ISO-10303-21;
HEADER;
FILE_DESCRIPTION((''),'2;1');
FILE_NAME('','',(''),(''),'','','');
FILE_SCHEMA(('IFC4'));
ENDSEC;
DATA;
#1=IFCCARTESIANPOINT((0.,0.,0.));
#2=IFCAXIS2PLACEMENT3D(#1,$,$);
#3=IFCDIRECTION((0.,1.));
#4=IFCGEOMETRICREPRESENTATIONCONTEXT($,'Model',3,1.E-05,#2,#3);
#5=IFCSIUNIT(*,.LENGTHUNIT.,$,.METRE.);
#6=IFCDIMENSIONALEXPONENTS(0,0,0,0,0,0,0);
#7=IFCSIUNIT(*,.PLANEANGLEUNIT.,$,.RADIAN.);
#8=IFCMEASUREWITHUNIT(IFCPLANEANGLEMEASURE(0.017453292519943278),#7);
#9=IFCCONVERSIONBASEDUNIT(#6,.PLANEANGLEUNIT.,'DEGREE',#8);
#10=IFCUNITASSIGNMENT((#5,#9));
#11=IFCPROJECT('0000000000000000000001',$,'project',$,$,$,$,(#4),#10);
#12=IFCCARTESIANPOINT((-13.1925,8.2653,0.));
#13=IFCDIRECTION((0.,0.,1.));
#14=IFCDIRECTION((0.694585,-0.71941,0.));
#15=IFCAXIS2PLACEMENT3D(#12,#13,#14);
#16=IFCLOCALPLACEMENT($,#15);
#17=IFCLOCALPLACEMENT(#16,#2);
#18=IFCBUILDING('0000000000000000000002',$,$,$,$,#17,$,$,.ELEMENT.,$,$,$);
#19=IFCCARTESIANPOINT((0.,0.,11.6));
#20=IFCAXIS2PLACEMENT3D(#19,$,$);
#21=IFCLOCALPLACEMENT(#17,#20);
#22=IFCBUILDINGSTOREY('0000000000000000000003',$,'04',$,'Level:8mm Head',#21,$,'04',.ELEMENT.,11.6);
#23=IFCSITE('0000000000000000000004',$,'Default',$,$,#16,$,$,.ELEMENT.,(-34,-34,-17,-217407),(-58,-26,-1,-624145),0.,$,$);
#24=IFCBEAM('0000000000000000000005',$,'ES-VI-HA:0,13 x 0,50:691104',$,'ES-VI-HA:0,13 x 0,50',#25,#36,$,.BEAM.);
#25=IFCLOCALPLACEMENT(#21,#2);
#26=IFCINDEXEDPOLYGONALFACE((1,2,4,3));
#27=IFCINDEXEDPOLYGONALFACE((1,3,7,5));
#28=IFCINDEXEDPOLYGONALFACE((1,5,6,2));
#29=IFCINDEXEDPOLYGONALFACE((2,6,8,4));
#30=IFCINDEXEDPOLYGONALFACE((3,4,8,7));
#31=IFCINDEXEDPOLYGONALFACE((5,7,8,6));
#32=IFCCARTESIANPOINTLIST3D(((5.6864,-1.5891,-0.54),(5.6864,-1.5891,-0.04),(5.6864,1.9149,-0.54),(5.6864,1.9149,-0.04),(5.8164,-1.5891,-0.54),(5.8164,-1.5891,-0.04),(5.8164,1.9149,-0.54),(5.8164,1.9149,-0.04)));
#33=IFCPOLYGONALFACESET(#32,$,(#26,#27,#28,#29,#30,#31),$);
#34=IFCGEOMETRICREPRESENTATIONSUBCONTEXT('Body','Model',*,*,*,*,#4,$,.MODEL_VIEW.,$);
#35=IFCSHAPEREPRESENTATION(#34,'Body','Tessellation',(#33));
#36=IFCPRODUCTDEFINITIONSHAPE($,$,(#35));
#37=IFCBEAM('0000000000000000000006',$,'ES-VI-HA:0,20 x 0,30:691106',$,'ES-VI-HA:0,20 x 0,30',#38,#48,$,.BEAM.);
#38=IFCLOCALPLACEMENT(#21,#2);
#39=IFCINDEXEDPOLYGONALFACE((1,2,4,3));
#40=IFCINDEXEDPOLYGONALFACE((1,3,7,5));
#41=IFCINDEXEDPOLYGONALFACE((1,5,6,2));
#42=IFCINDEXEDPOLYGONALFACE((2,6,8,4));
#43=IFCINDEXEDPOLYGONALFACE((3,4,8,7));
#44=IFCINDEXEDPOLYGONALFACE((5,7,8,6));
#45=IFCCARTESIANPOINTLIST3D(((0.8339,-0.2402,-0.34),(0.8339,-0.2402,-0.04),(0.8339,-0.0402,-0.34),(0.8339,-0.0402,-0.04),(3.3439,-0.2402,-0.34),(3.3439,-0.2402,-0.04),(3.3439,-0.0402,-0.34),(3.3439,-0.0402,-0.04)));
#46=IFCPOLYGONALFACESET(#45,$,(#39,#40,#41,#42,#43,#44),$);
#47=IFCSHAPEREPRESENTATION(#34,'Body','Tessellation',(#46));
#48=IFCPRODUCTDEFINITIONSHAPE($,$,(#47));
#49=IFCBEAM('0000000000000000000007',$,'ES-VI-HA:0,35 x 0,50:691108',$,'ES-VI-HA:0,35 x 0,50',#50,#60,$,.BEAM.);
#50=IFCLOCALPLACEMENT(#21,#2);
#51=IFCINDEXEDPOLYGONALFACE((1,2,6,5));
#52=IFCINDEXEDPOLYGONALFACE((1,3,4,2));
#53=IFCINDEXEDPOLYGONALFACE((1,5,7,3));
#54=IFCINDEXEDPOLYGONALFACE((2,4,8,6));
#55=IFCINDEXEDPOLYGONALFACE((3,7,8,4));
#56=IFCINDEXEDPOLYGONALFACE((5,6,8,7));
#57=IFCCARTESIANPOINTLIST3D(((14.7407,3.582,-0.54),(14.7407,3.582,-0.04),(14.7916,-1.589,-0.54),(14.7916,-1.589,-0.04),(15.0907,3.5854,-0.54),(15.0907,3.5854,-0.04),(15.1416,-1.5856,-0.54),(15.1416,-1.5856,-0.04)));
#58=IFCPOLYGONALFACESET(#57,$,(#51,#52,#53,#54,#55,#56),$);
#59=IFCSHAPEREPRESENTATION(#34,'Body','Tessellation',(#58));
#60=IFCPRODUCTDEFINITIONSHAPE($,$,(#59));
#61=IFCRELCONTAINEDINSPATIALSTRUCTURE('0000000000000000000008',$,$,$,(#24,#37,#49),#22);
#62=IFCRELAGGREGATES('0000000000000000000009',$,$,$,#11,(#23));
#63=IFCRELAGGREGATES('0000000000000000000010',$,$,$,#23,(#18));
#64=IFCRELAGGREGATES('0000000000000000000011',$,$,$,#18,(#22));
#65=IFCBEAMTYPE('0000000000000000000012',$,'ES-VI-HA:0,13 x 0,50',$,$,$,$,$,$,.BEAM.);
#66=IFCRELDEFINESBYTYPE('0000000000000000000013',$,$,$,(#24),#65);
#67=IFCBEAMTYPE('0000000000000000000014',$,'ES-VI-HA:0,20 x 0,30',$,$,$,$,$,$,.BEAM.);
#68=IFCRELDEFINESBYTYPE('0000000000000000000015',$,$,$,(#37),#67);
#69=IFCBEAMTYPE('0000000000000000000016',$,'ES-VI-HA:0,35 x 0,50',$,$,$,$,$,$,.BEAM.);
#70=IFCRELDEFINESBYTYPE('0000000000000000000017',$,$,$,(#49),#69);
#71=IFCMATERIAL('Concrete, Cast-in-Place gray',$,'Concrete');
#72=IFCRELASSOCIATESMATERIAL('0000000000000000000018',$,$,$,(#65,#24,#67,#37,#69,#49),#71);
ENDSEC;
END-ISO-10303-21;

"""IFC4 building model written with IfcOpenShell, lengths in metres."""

from ifc_helpers import new_model, entity, si_unit, converted_unit, direction, frame, origin, place, context, subcontext, project, spatial, indexed_curve, outline, extrude, source, transform, mapped, material, type_object, type_shapes, element, save


model = new_model("IFC4")

# Units and contexts
model_context = context("Model", 3, precision=1e-05, world=origin(), true_north=direction((0.0, 1.0)))
body_context = subcontext(model_context, "Body", "Model", "MODEL_VIEW")
ifc_project = project(units=[si_unit("LENGTHUNIT", "METRE"), converted_unit("PLANEANGLEUNIT", "DEGREE", entity("IfcPlaneAngleMeasure", 0.017453292519943278), si_unit("PLANEANGLEUNIT", "RADIAN"), dimensions=[0, 0, 0, 0, 0, 0, 0])], contexts=[model_context])

# Site, building, storey
site_placement = place(None, frame((-13.1925, 8.2653, 0.0), z_axis=(0.0, 0.0, 1.0), x_axis=(0.694585, -0.71941, 0.0)))
site = spatial("IfcSite", under=ifc_project, at=site_placement, Name="Default", CompositionType="ELEMENT", RefLatitude=(-34, -34, -17, -217407), RefLongitude=(-58, -26, -1, -624145), RefElevation=0.0)
building_placement = place(site_placement, origin())
building = spatial("IfcBuilding", under=site, at=building_placement, CompositionType="ELEMENT")
storey_placement = place(building_placement, frame((0.0, 0.0, 11.6)))
storey = spatial("IfcBuildingStorey", under=building, at=storey_placement, Name="04", ObjectType="Level:8mm Head", LongName="04", CompositionType="ELEMENT", Elevation=11.6)

# Beams
ifc_material = material(Name="Concrete, Cast-in-Place gray", Category="Concrete")
beam_type_1 = type_object("IfcBeamType", Name="ES-VI-HA:0,13 x 0,50", PredefinedType="BEAM", material=ifc_material)
shared_shape_1 = source(origin(), body_context, "Body", "SweptSolid", [
    extrude(outline(indexed_curve([(-0.065, -0.25), (0.065, -0.25), (0.065, 0.25), (-0.065, 0.25), (-0.065, -0.25)], self_intersect=False)), frame((5.7514, -1.5891, 11.31), z_axis=(0.0, 1.0, 0.0), x_axis=(-1.0, 0.0, 0.0)), (0.0, 0.0, 1.0), 3.5039),
])
type_shapes(beam_type_1, [shared_shape_1])
beam_1_placement = place(storey_placement, frame((0.0, 0.0, -11.6)))
element("IfcBeam", 1, at=beam_1_placement, inside=storey, type_object=beam_type_1, material=ifc_material, Name="ES-VI-HA:0,13 x 0,50:691104", ObjectType="ES-VI-HA:0,13 x 0,50", PredefinedType="BEAM", context=body_context, shape_type="MappedRepresentation", body=[
    mapped(shared_shape_1, transform((0.0, 0.0, 0.0), scale=1.0)),
])
beam_type_2 = type_object("IfcBeamType", Name="ES-VI-HA:0,20 x 0,30", PredefinedType="BEAM", material=ifc_material)
shared_shape_2 = source(origin(), body_context, "Body", "SweptSolid", [
    extrude(outline(indexed_curve([(-0.15, -0.1), (0.15, -0.1), (0.15, 0.1), (-0.15, 0.1), (-0.15, -0.1)], self_intersect=False)), frame((0.8339, -0.1402, 11.41), z_axis=(1.0, 0.0, 0.0), x_axis=(0.0, 0.0, -1.0)), (0.0, 0.0, 1.0), 2.51),
])
type_shapes(beam_type_2, [shared_shape_2])
beam_2_placement = place(storey_placement, frame((0.0, 0.0, -11.6)))
element("IfcBeam", 2, at=beam_2_placement, inside=storey, type_object=beam_type_2, material=ifc_material, Name="ES-VI-HA:0,20 x 0,30:691106", ObjectType="ES-VI-HA:0,20 x 0,30", PredefinedType="BEAM", context=body_context, shape_type="MappedRepresentation", body=[
    mapped(shared_shape_2, transform((0.0, 0.0, 0.0), scale=1.0)),
])
beam_type_3 = type_object("IfcBeamType", Name="ES-VI-HA:0,35 x 0,50", PredefinedType="BEAM", material=ifc_material)
shared_shape_3 = source(origin(), body_context, "Body", "SweptSolid", [
    extrude(outline(indexed_curve([(-0.25, -0.175), (0.25, -0.175), (0.25, 0.175), (-0.25, 0.175), (-0.25, -0.175)], self_intersect=False)), frame((14.9157, 3.5837, 11.31), z_axis=(0.009844, -0.999952, 0.0), x_axis=(0.0, 0.0, -1.0)), (0.0, 0.0, 1.0), 5.1713),
])
type_shapes(beam_type_3, [shared_shape_3])
beam_3_placement = place(storey_placement, frame((0.0, 0.0, -11.6)))
element("IfcBeam", 3, at=beam_3_placement, inside=storey, type_object=beam_type_3, material=ifc_material, Name="ES-VI-HA:0,35 x 0,50:691108", ObjectType="ES-VI-HA:0,35 x 0,50", PredefinedType="BEAM", context=body_context, shape_type="MappedRepresentation", body=[
    mapped(shared_shape_3, transform((0.0, 0.0, 0.0), scale=1.0)),
])

save(model, "model.ifc")
